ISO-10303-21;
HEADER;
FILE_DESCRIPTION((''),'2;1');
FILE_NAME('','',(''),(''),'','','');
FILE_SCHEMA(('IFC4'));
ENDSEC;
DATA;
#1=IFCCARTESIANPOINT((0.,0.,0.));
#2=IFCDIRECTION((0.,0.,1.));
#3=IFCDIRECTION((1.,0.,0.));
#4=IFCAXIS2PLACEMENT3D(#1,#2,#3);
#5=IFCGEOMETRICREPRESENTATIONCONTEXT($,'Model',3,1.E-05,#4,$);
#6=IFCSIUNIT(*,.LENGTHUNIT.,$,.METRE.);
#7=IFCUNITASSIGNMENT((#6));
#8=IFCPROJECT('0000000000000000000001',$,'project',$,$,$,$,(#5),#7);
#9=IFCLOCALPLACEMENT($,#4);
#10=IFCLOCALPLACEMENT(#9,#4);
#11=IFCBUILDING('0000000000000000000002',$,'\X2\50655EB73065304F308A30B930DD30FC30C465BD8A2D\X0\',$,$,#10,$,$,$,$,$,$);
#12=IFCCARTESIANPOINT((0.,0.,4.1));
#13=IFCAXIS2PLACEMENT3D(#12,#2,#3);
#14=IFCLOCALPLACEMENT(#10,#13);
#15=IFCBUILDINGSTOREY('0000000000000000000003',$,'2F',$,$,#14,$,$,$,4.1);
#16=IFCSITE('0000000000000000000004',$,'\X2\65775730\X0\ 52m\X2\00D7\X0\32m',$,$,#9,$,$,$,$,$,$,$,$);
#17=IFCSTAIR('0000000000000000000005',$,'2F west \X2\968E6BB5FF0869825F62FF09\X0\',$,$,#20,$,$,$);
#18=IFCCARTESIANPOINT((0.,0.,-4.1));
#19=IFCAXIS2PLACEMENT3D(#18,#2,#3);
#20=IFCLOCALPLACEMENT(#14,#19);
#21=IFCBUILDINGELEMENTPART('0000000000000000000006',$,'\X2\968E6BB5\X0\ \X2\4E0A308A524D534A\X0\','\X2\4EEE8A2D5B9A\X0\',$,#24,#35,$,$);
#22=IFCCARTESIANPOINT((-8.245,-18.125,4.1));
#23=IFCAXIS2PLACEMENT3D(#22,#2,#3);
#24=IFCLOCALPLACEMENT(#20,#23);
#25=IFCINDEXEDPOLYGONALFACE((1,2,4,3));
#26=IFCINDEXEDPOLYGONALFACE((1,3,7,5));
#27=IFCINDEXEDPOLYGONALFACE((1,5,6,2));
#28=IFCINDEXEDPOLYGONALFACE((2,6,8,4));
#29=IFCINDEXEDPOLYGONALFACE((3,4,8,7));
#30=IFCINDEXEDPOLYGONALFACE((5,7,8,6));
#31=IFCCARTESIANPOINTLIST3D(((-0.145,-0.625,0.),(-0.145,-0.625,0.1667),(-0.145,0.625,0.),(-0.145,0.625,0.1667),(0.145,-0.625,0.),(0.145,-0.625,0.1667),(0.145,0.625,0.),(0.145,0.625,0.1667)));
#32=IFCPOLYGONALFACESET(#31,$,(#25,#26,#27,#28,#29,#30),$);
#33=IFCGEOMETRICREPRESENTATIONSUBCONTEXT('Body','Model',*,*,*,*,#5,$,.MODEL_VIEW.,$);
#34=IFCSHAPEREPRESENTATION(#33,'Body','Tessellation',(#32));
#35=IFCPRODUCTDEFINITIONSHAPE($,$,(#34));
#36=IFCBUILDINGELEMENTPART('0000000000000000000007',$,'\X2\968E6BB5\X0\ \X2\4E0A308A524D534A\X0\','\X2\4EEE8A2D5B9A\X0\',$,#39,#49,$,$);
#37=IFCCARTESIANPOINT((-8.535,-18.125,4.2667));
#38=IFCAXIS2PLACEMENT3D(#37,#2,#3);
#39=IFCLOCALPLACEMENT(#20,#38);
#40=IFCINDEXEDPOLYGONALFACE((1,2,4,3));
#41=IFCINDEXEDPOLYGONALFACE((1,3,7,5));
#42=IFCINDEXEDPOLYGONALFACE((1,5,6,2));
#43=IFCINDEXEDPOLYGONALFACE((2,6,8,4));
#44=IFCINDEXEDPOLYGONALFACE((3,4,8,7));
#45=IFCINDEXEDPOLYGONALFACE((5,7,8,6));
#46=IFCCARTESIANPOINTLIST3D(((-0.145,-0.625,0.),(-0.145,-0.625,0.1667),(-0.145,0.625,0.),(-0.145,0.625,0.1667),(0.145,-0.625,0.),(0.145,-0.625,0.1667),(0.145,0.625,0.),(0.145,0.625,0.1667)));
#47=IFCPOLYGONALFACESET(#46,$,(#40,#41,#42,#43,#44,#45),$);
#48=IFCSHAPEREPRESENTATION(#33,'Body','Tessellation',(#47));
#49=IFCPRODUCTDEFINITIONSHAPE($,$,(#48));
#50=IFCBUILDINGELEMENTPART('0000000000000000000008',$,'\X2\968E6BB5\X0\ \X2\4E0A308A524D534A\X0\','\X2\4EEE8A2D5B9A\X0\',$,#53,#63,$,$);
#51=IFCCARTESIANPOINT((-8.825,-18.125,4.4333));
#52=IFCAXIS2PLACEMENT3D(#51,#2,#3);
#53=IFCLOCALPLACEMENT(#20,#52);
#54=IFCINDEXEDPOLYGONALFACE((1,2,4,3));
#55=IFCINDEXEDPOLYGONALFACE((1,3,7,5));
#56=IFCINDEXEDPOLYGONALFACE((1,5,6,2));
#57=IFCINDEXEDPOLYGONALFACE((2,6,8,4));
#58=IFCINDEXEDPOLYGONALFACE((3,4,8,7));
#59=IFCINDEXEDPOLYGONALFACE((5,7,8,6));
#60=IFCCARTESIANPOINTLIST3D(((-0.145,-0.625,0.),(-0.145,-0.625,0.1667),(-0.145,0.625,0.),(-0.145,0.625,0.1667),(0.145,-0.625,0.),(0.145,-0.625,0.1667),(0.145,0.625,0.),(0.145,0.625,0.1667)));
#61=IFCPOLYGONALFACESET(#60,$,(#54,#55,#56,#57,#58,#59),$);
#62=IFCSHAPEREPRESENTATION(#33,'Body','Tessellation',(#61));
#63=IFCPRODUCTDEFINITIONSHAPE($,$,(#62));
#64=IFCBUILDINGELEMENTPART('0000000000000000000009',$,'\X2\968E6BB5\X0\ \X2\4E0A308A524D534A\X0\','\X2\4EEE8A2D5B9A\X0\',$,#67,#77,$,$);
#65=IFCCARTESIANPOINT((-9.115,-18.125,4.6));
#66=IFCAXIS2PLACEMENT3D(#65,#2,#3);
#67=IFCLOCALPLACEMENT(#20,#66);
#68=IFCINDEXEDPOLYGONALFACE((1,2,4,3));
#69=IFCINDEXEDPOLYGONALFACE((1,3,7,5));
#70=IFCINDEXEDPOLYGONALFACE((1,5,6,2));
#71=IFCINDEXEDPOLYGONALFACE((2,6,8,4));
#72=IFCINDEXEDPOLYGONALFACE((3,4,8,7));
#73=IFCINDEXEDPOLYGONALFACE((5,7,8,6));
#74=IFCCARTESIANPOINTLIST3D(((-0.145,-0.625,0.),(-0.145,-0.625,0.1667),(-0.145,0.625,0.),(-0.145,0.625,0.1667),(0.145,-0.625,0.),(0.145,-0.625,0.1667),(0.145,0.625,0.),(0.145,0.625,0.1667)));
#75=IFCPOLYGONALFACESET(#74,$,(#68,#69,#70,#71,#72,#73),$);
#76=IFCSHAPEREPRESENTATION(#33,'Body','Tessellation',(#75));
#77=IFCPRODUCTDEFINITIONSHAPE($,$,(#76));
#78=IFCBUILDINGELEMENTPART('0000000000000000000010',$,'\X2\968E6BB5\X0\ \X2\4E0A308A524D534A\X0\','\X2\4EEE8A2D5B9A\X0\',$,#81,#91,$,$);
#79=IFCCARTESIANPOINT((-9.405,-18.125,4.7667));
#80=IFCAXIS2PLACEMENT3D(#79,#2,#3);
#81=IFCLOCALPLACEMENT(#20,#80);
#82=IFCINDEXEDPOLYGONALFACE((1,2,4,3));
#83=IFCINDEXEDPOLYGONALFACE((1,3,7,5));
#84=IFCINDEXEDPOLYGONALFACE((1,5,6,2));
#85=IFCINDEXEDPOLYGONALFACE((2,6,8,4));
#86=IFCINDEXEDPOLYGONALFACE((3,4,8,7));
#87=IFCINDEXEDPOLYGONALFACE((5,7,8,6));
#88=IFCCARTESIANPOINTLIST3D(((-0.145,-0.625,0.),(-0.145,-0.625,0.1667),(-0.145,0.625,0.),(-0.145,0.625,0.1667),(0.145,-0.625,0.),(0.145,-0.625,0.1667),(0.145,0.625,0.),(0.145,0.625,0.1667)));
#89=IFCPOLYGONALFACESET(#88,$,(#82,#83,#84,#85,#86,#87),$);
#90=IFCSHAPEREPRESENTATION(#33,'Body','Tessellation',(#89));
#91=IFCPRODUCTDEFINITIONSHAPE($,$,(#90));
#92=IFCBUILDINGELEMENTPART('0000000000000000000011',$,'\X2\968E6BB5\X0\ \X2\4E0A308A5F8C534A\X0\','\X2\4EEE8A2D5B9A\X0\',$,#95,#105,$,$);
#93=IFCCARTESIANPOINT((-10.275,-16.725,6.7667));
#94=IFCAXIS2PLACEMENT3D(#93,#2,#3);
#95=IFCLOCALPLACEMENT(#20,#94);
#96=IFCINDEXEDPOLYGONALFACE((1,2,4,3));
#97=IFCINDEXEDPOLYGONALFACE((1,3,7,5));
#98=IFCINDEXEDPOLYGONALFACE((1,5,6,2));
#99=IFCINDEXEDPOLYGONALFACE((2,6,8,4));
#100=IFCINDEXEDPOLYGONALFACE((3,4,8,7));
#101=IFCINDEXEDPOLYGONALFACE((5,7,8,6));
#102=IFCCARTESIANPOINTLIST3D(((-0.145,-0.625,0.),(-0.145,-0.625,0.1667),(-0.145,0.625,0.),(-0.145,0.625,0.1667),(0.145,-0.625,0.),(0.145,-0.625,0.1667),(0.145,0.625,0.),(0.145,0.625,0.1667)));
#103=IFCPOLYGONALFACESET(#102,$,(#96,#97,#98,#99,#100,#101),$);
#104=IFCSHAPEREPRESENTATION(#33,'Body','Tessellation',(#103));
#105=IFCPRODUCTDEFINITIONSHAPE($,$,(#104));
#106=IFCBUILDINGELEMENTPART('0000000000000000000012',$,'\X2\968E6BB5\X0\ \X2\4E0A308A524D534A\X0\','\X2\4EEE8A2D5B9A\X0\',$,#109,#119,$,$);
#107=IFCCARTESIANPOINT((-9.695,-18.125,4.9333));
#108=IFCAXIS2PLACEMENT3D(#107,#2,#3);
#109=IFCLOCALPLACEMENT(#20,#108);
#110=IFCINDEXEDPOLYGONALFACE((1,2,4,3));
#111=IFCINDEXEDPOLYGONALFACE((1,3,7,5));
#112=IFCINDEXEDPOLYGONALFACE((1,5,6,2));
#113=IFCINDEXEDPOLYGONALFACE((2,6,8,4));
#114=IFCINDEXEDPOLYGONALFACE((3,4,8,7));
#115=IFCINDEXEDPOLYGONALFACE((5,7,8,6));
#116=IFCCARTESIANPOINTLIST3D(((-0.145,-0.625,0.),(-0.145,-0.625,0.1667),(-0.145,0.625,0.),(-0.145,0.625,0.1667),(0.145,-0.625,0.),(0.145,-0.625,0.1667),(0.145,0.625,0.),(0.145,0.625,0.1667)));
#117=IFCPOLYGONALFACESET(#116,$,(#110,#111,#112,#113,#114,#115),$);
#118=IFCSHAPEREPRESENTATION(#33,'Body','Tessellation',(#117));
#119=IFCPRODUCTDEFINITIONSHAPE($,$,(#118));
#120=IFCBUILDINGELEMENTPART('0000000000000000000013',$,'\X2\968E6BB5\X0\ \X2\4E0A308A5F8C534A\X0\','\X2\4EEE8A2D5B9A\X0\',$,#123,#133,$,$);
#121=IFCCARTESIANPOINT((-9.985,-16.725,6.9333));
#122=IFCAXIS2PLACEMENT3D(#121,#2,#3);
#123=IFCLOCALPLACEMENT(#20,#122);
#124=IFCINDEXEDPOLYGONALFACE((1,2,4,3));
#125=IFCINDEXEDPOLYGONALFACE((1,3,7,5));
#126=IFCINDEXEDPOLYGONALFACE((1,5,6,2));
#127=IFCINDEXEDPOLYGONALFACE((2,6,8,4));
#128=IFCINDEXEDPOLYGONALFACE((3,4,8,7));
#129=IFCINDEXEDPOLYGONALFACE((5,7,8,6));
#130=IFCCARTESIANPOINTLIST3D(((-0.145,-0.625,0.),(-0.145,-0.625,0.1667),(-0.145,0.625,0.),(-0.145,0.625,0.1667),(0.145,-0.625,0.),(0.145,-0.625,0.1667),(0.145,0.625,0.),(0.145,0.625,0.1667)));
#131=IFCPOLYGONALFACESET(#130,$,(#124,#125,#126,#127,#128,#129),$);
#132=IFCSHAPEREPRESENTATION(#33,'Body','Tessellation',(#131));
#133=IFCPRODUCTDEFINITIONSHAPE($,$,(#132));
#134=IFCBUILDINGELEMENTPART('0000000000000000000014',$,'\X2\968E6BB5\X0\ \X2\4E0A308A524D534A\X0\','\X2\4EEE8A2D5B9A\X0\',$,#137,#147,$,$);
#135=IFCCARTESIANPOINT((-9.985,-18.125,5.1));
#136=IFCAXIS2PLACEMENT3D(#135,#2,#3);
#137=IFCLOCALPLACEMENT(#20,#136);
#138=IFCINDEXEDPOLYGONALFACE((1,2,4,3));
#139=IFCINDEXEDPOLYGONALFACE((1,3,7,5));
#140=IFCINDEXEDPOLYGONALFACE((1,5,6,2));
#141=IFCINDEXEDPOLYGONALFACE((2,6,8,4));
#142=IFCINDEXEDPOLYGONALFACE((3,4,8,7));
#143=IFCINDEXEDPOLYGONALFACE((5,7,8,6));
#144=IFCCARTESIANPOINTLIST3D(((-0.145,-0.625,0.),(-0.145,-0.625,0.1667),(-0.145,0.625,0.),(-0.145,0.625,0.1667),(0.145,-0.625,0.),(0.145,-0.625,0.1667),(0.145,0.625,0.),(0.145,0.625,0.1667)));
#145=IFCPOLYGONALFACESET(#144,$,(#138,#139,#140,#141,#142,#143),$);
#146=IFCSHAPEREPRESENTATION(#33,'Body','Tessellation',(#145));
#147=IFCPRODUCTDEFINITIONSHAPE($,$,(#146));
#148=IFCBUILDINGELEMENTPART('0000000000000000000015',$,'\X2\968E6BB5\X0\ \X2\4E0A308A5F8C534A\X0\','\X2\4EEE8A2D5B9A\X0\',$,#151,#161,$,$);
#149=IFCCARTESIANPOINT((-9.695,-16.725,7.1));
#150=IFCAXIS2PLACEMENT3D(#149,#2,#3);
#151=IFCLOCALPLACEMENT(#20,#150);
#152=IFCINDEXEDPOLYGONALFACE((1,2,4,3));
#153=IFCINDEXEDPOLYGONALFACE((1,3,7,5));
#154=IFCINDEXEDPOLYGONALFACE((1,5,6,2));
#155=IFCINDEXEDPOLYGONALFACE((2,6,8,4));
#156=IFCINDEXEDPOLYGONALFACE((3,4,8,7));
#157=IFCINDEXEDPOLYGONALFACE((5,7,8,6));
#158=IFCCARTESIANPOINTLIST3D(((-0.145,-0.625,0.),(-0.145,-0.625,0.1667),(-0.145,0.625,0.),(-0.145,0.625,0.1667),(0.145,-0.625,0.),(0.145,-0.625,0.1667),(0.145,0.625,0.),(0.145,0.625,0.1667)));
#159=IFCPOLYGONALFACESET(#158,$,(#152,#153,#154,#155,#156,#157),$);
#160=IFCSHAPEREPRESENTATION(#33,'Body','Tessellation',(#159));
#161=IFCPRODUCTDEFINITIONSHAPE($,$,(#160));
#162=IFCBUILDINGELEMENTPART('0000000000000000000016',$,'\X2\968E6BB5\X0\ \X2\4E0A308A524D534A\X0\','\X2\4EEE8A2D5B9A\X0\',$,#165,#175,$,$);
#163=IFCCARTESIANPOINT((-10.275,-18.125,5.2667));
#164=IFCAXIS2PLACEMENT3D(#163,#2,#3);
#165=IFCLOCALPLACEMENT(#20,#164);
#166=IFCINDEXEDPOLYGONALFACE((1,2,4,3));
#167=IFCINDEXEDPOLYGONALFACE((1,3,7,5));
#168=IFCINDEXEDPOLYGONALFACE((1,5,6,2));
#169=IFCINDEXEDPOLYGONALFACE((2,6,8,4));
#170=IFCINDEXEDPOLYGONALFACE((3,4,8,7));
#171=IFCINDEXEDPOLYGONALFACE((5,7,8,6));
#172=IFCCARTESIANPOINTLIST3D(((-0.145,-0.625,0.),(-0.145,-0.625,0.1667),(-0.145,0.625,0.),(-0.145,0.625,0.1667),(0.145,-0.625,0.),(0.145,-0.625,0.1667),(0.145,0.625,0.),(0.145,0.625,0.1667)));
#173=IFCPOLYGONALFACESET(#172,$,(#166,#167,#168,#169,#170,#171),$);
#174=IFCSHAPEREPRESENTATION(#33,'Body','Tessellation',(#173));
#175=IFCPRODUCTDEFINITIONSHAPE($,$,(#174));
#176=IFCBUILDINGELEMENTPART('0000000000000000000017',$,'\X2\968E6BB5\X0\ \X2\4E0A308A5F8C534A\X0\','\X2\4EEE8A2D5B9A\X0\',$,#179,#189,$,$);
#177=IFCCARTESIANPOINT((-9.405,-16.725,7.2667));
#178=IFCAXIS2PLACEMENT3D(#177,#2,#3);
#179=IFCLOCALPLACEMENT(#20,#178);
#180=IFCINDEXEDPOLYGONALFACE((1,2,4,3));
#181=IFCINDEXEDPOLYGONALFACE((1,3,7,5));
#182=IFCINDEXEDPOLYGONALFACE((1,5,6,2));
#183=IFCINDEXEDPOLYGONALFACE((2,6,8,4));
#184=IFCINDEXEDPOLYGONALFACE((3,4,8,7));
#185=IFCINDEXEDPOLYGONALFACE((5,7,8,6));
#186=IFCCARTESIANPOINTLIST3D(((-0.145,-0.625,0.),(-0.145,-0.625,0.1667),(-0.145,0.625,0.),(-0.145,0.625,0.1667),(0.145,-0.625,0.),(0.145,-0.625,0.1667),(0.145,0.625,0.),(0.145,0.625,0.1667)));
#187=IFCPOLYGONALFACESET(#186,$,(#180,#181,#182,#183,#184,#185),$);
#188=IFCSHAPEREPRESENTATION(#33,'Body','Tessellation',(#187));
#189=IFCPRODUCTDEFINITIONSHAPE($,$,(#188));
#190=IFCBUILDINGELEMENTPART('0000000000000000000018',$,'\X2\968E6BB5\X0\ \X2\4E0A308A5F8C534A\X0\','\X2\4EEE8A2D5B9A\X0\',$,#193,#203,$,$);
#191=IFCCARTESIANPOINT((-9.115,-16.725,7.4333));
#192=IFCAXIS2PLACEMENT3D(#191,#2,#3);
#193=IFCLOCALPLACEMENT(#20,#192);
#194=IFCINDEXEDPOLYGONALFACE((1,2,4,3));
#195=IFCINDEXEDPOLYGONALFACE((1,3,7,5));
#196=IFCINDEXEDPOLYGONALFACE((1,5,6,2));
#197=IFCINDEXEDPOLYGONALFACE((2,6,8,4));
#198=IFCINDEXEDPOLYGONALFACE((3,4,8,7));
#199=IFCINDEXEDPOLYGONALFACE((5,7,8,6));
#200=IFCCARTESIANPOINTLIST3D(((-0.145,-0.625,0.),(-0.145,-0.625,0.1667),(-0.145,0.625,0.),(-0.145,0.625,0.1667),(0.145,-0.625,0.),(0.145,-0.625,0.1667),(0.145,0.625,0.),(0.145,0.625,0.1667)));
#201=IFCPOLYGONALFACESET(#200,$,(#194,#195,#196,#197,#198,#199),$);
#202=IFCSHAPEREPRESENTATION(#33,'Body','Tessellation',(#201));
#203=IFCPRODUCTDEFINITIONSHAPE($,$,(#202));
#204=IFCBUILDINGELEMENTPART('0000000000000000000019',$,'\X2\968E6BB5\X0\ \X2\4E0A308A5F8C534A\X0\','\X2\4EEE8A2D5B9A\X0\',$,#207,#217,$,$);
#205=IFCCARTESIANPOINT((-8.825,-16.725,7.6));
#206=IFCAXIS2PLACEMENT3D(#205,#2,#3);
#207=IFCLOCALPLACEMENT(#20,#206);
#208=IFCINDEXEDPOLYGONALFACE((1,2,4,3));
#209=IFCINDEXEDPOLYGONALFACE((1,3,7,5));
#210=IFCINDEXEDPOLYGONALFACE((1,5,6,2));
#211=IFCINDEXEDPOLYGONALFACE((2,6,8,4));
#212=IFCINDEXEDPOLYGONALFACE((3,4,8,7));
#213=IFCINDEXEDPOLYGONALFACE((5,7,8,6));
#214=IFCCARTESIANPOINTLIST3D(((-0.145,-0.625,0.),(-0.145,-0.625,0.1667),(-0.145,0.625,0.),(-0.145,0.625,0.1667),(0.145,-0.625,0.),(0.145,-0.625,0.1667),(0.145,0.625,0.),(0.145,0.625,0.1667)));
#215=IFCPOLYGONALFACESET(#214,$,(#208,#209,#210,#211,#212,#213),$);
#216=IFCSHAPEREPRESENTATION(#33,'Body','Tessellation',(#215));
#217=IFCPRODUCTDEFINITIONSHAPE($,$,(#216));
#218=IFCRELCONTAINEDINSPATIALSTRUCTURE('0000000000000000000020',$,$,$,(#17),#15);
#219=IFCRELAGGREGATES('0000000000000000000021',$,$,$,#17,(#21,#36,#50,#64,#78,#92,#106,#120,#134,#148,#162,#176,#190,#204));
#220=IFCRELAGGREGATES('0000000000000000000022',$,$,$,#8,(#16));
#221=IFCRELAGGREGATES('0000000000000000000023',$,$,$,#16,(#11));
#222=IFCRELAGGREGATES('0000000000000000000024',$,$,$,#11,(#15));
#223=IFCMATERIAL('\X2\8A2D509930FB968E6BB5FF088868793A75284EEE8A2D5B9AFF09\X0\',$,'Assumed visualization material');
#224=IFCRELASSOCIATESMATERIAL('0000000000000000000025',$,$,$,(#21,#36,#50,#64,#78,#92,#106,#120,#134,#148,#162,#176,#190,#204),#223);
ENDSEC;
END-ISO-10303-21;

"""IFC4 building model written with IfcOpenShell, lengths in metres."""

from ifc_helpers import new_model, si_unit, frame, origin_with_axes, place, context, subcontext, project, spatial, rectangle, extrude, material, element, aggregate, save


model = new_model("IFC4")

# Units and contexts
model_context = context("Model", 3, precision=1e-05, world=origin_with_axes())
body_context = subcontext(model_context, "Body", "Model", "MODEL_VIEW")
ifc_project = project(units=[si_unit("LENGTHUNIT", "METRE")], contexts=[model_context])

# Site, building, storey
site_placement = place(None, origin_with_axes())
site = spatial("IfcSite", under=ifc_project, at=site_placement, Name="敷地 52m×32m")
building_placement = place(site_placement, origin_with_axes())
building = spatial("IfcBuilding", under=site, at=building_placement, Name="健康づくりスポーツ施設")
storey_placement = place(building_placement, frame((0.0, 0.0, 4.1), z_axis=(0.0, 0.0, 1.0), x_axis=(1.0, 0.0, 0.0)))
storey = spatial("IfcBuildingStorey", under=building, at=storey_placement, Name="2F", Elevation=4.1)

# Stair, building element parts
stair_placement = place(storey_placement, frame((0.0, 0.0, -4.1), z_axis=(0.0, 0.0, 1.0), x_axis=(1.0, 0.0, 0.0)))
stair = element("IfcStair", 1, at=stair_placement, inside=storey, Name="2F west 階段（概形）")
ifc_material_1 = material(Name="設備・階段（表示用仮設定）", Category="Assumed visualization material")
building_element_part_1_placement = place(stair_placement, frame((-8.245, -18.125, 4.1), z_axis=(0.0, 0.0, 1.0), x_axis=(1.0, 0.0, 0.0)))
building_element_part_1 = element("IfcBuildingElementPart", 2, at=building_element_part_1_placement, material=ifc_material_1, Name="階段 上り前半", Description="仮設定", context=body_context, shape_type="SweptSolid", body=[
    extrude(rectangle(XDim=0.29, YDim=1.25), origin_with_axes(), (0.0, 0.0, 1.0), 0.1667),
])
building_element_part_2_placement = place(stair_placement, frame((-8.535, -18.125, 4.2667), z_axis=(0.0, 0.0, 1.0), x_axis=(1.0, 0.0, 0.0)))
building_element_part_2 = element("IfcBuildingElementPart", 3, at=building_element_part_2_placement, material=ifc_material_1, Name="階段 上り前半", Description="仮設定", context=body_context, shape_type="SweptSolid", body=[
    extrude(rectangle(XDim=0.29, YDim=1.25), origin_with_axes(), (0.0, 0.0, 1.0), 0.1667),
])
building_element_part_3_placement = place(stair_placement, frame((-8.825, -18.125, 4.4333), z_axis=(0.0, 0.0, 1.0), x_axis=(1.0, 0.0, 0.0)))
building_element_part_3 = element("IfcBuildingElementPart", 4, at=building_element_part_3_placement, material=ifc_material_1, Name="階段 上り前半", Description="仮設定", context=body_context, shape_type="SweptSolid", body=[
    extrude(rectangle(XDim=0.29, YDim=1.25), origin_with_axes(), (0.0, 0.0, 1.0), 0.1667),
])
building_element_part_4_placement = place(stair_placement, frame((-9.115, -18.125, 4.6), z_axis=(0.0, 0.0, 1.0), x_axis=(1.0, 0.0, 0.0)))
building_element_part_4 = element("IfcBuildingElementPart", 5, at=building_element_part_4_placement, material=ifc_material_1, Name="階段 上り前半", Description="仮設定", context=body_context, shape_type="SweptSolid", body=[
    extrude(rectangle(XDim=0.29, YDim=1.25), origin_with_axes(), (0.0, 0.0, 1.0), 0.1667),
])
building_element_part_5_placement = place(stair_placement, frame((-9.405, -18.125, 4.7667), z_axis=(0.0, 0.0, 1.0), x_axis=(1.0, 0.0, 0.0)))
building_element_part_5 = element("IfcBuildingElementPart", 6, at=building_element_part_5_placement, material=ifc_material_1, Name="階段 上り前半", Description="仮設定", context=body_context, shape_type="SweptSolid", body=[
    extrude(rectangle(XDim=0.29, YDim=1.25), origin_with_axes(), (0.0, 0.0, 1.0), 0.1667),
])
building_element_part_6_placement = place(stair_placement, frame((-10.275, -16.725, 6.7667), z_axis=(0.0, 0.0, 1.0), x_axis=(1.0, 0.0, 0.0)))
building_element_part_6 = element("IfcBuildingElementPart", 7, at=building_element_part_6_placement, material=ifc_material_1, Name="階段 上り後半", Description="仮設定", context=body_context, shape_type="SweptSolid", body=[
    extrude(rectangle(XDim=0.29, YDim=1.25), origin_with_axes(), (0.0, 0.0, 1.0), 0.1667),
])
building_element_part_7_placement = place(stair_placement, frame((-9.695, -18.125, 4.9333), z_axis=(0.0, 0.0, 1.0), x_axis=(1.0, 0.0, 0.0)))
building_element_part_7 = element("IfcBuildingElementPart", 8, at=building_element_part_7_placement, material=ifc_material_1, Name="階段 上り前半", Description="仮設定", context=body_context, shape_type="SweptSolid", body=[
    extrude(rectangle(XDim=0.29, YDim=1.25), origin_with_axes(), (0.0, 0.0, 1.0), 0.1667),
])
building_element_part_8_placement = place(stair_placement, frame((-9.985, -16.725, 6.9333), z_axis=(0.0, 0.0, 1.0), x_axis=(1.0, 0.0, 0.0)))
building_element_part_8 = element("IfcBuildingElementPart", 9, at=building_element_part_8_placement, material=ifc_material_1, Name="階段 上り後半", Description="仮設定", context=body_context, shape_type="SweptSolid", body=[
    extrude(rectangle(XDim=0.29, YDim=1.25), origin_with_axes(), (0.0, 0.0, 1.0), 0.1667),
])
building_element_part_9_placement = place(stair_placement, frame((-9.985, -18.125, 5.1), z_axis=(0.0, 0.0, 1.0), x_axis=(1.0, 0.0, 0.0)))
building_element_part_9 = element("IfcBuildingElementPart", 10, at=building_element_part_9_placement, material=ifc_material_1, Name="階段 上り前半", Description="仮設定", context=body_context, shape_type="SweptSolid", body=[
    extrude(rectangle(XDim=0.29, YDim=1.25), origin_with_axes(), (0.0, 0.0, 1.0), 0.1667),
])
building_element_part_10_placement = place(stair_placement, frame((-9.695, -16.725, 7.1), z_axis=(0.0, 0.0, 1.0), x_axis=(1.0, 0.0, 0.0)))
building_element_part_10 = element("IfcBuildingElementPart", 11, at=building_element_part_10_placement, material=ifc_material_1, Name="階段 上り後半", Description="仮設定", context=body_context, shape_type="SweptSolid", body=[
    extrude(rectangle(XDim=0.29, YDim=1.25), origin_with_axes(), (0.0, 0.0, 1.0), 0.1667),
])
building_element_part_11_placement = place(stair_placement, frame((-10.275, -18.125, 5.2667), z_axis=(0.0, 0.0, 1.0), x_axis=(1.0, 0.0, 0.0)))
building_element_part_11 = element("IfcBuildingElementPart", 12, at=building_element_part_11_placement, material=ifc_material_1, Name="階段 上り前半", Description="仮設定", context=body_context, shape_type="SweptSolid", body=[
    extrude(rectangle(XDim=0.29, YDim=1.25), origin_with_axes(), (0.0, 0.0, 1.0), 0.1667),
])
building_element_part_12_placement = place(stair_placement, frame((-9.405, -16.725, 7.2667), z_axis=(0.0, 0.0, 1.0), x_axis=(1.0, 0.0, 0.0)))
building_element_part_12 = element("IfcBuildingElementPart", 13, at=building_element_part_12_placement, material=ifc_material_1, Name="階段 上り後半", Description="仮設定", context=body_context, shape_type="SweptSolid", body=[
    extrude(rectangle(XDim=0.29, YDim=1.25), origin_with_axes(), (0.0, 0.0, 1.0), 0.1667),
])
building_element_part_13_placement = place(stair_placement, frame((-9.115, -16.725, 7.4333), z_axis=(0.0, 0.0, 1.0), x_axis=(1.0, 0.0, 0.0)))
building_element_part_13 = element("IfcBuildingElementPart", 14, at=building_element_part_13_placement, material=ifc_material_1, Name="階段 上り後半", Description="仮設定", context=body_context, shape_type="SweptSolid", body=[
    extrude(rectangle(XDim=0.29, YDim=1.25), origin_with_axes(), (0.0, 0.0, 1.0), 0.1667),
])
building_element_part_14_placement = place(stair_placement, frame((-8.825, -16.725, 7.6), z_axis=(0.0, 0.0, 1.0), x_axis=(1.0, 0.0, 0.0)))
building_element_part_14 = element("IfcBuildingElementPart", 15, at=building_element_part_14_placement, material=ifc_material_1, Name="階段 上り後半", Description="仮設定", context=body_context, shape_type="SweptSolid", body=[
    extrude(rectangle(XDim=0.29, YDim=1.25), origin_with_axes(), (0.0, 0.0, 1.0), 0.1667),
])
aggregate(stair, [building_element_part_1, building_element_part_2, building_element_part_3, building_element_part_4, building_element_part_5, building_element_part_6, building_element_part_7, building_element_part_8, building_element_part_9, building_element_part_10, building_element_part_11, building_element_part_12, building_element_part_13, building_element_part_14])

save(model, "model.ifc")
